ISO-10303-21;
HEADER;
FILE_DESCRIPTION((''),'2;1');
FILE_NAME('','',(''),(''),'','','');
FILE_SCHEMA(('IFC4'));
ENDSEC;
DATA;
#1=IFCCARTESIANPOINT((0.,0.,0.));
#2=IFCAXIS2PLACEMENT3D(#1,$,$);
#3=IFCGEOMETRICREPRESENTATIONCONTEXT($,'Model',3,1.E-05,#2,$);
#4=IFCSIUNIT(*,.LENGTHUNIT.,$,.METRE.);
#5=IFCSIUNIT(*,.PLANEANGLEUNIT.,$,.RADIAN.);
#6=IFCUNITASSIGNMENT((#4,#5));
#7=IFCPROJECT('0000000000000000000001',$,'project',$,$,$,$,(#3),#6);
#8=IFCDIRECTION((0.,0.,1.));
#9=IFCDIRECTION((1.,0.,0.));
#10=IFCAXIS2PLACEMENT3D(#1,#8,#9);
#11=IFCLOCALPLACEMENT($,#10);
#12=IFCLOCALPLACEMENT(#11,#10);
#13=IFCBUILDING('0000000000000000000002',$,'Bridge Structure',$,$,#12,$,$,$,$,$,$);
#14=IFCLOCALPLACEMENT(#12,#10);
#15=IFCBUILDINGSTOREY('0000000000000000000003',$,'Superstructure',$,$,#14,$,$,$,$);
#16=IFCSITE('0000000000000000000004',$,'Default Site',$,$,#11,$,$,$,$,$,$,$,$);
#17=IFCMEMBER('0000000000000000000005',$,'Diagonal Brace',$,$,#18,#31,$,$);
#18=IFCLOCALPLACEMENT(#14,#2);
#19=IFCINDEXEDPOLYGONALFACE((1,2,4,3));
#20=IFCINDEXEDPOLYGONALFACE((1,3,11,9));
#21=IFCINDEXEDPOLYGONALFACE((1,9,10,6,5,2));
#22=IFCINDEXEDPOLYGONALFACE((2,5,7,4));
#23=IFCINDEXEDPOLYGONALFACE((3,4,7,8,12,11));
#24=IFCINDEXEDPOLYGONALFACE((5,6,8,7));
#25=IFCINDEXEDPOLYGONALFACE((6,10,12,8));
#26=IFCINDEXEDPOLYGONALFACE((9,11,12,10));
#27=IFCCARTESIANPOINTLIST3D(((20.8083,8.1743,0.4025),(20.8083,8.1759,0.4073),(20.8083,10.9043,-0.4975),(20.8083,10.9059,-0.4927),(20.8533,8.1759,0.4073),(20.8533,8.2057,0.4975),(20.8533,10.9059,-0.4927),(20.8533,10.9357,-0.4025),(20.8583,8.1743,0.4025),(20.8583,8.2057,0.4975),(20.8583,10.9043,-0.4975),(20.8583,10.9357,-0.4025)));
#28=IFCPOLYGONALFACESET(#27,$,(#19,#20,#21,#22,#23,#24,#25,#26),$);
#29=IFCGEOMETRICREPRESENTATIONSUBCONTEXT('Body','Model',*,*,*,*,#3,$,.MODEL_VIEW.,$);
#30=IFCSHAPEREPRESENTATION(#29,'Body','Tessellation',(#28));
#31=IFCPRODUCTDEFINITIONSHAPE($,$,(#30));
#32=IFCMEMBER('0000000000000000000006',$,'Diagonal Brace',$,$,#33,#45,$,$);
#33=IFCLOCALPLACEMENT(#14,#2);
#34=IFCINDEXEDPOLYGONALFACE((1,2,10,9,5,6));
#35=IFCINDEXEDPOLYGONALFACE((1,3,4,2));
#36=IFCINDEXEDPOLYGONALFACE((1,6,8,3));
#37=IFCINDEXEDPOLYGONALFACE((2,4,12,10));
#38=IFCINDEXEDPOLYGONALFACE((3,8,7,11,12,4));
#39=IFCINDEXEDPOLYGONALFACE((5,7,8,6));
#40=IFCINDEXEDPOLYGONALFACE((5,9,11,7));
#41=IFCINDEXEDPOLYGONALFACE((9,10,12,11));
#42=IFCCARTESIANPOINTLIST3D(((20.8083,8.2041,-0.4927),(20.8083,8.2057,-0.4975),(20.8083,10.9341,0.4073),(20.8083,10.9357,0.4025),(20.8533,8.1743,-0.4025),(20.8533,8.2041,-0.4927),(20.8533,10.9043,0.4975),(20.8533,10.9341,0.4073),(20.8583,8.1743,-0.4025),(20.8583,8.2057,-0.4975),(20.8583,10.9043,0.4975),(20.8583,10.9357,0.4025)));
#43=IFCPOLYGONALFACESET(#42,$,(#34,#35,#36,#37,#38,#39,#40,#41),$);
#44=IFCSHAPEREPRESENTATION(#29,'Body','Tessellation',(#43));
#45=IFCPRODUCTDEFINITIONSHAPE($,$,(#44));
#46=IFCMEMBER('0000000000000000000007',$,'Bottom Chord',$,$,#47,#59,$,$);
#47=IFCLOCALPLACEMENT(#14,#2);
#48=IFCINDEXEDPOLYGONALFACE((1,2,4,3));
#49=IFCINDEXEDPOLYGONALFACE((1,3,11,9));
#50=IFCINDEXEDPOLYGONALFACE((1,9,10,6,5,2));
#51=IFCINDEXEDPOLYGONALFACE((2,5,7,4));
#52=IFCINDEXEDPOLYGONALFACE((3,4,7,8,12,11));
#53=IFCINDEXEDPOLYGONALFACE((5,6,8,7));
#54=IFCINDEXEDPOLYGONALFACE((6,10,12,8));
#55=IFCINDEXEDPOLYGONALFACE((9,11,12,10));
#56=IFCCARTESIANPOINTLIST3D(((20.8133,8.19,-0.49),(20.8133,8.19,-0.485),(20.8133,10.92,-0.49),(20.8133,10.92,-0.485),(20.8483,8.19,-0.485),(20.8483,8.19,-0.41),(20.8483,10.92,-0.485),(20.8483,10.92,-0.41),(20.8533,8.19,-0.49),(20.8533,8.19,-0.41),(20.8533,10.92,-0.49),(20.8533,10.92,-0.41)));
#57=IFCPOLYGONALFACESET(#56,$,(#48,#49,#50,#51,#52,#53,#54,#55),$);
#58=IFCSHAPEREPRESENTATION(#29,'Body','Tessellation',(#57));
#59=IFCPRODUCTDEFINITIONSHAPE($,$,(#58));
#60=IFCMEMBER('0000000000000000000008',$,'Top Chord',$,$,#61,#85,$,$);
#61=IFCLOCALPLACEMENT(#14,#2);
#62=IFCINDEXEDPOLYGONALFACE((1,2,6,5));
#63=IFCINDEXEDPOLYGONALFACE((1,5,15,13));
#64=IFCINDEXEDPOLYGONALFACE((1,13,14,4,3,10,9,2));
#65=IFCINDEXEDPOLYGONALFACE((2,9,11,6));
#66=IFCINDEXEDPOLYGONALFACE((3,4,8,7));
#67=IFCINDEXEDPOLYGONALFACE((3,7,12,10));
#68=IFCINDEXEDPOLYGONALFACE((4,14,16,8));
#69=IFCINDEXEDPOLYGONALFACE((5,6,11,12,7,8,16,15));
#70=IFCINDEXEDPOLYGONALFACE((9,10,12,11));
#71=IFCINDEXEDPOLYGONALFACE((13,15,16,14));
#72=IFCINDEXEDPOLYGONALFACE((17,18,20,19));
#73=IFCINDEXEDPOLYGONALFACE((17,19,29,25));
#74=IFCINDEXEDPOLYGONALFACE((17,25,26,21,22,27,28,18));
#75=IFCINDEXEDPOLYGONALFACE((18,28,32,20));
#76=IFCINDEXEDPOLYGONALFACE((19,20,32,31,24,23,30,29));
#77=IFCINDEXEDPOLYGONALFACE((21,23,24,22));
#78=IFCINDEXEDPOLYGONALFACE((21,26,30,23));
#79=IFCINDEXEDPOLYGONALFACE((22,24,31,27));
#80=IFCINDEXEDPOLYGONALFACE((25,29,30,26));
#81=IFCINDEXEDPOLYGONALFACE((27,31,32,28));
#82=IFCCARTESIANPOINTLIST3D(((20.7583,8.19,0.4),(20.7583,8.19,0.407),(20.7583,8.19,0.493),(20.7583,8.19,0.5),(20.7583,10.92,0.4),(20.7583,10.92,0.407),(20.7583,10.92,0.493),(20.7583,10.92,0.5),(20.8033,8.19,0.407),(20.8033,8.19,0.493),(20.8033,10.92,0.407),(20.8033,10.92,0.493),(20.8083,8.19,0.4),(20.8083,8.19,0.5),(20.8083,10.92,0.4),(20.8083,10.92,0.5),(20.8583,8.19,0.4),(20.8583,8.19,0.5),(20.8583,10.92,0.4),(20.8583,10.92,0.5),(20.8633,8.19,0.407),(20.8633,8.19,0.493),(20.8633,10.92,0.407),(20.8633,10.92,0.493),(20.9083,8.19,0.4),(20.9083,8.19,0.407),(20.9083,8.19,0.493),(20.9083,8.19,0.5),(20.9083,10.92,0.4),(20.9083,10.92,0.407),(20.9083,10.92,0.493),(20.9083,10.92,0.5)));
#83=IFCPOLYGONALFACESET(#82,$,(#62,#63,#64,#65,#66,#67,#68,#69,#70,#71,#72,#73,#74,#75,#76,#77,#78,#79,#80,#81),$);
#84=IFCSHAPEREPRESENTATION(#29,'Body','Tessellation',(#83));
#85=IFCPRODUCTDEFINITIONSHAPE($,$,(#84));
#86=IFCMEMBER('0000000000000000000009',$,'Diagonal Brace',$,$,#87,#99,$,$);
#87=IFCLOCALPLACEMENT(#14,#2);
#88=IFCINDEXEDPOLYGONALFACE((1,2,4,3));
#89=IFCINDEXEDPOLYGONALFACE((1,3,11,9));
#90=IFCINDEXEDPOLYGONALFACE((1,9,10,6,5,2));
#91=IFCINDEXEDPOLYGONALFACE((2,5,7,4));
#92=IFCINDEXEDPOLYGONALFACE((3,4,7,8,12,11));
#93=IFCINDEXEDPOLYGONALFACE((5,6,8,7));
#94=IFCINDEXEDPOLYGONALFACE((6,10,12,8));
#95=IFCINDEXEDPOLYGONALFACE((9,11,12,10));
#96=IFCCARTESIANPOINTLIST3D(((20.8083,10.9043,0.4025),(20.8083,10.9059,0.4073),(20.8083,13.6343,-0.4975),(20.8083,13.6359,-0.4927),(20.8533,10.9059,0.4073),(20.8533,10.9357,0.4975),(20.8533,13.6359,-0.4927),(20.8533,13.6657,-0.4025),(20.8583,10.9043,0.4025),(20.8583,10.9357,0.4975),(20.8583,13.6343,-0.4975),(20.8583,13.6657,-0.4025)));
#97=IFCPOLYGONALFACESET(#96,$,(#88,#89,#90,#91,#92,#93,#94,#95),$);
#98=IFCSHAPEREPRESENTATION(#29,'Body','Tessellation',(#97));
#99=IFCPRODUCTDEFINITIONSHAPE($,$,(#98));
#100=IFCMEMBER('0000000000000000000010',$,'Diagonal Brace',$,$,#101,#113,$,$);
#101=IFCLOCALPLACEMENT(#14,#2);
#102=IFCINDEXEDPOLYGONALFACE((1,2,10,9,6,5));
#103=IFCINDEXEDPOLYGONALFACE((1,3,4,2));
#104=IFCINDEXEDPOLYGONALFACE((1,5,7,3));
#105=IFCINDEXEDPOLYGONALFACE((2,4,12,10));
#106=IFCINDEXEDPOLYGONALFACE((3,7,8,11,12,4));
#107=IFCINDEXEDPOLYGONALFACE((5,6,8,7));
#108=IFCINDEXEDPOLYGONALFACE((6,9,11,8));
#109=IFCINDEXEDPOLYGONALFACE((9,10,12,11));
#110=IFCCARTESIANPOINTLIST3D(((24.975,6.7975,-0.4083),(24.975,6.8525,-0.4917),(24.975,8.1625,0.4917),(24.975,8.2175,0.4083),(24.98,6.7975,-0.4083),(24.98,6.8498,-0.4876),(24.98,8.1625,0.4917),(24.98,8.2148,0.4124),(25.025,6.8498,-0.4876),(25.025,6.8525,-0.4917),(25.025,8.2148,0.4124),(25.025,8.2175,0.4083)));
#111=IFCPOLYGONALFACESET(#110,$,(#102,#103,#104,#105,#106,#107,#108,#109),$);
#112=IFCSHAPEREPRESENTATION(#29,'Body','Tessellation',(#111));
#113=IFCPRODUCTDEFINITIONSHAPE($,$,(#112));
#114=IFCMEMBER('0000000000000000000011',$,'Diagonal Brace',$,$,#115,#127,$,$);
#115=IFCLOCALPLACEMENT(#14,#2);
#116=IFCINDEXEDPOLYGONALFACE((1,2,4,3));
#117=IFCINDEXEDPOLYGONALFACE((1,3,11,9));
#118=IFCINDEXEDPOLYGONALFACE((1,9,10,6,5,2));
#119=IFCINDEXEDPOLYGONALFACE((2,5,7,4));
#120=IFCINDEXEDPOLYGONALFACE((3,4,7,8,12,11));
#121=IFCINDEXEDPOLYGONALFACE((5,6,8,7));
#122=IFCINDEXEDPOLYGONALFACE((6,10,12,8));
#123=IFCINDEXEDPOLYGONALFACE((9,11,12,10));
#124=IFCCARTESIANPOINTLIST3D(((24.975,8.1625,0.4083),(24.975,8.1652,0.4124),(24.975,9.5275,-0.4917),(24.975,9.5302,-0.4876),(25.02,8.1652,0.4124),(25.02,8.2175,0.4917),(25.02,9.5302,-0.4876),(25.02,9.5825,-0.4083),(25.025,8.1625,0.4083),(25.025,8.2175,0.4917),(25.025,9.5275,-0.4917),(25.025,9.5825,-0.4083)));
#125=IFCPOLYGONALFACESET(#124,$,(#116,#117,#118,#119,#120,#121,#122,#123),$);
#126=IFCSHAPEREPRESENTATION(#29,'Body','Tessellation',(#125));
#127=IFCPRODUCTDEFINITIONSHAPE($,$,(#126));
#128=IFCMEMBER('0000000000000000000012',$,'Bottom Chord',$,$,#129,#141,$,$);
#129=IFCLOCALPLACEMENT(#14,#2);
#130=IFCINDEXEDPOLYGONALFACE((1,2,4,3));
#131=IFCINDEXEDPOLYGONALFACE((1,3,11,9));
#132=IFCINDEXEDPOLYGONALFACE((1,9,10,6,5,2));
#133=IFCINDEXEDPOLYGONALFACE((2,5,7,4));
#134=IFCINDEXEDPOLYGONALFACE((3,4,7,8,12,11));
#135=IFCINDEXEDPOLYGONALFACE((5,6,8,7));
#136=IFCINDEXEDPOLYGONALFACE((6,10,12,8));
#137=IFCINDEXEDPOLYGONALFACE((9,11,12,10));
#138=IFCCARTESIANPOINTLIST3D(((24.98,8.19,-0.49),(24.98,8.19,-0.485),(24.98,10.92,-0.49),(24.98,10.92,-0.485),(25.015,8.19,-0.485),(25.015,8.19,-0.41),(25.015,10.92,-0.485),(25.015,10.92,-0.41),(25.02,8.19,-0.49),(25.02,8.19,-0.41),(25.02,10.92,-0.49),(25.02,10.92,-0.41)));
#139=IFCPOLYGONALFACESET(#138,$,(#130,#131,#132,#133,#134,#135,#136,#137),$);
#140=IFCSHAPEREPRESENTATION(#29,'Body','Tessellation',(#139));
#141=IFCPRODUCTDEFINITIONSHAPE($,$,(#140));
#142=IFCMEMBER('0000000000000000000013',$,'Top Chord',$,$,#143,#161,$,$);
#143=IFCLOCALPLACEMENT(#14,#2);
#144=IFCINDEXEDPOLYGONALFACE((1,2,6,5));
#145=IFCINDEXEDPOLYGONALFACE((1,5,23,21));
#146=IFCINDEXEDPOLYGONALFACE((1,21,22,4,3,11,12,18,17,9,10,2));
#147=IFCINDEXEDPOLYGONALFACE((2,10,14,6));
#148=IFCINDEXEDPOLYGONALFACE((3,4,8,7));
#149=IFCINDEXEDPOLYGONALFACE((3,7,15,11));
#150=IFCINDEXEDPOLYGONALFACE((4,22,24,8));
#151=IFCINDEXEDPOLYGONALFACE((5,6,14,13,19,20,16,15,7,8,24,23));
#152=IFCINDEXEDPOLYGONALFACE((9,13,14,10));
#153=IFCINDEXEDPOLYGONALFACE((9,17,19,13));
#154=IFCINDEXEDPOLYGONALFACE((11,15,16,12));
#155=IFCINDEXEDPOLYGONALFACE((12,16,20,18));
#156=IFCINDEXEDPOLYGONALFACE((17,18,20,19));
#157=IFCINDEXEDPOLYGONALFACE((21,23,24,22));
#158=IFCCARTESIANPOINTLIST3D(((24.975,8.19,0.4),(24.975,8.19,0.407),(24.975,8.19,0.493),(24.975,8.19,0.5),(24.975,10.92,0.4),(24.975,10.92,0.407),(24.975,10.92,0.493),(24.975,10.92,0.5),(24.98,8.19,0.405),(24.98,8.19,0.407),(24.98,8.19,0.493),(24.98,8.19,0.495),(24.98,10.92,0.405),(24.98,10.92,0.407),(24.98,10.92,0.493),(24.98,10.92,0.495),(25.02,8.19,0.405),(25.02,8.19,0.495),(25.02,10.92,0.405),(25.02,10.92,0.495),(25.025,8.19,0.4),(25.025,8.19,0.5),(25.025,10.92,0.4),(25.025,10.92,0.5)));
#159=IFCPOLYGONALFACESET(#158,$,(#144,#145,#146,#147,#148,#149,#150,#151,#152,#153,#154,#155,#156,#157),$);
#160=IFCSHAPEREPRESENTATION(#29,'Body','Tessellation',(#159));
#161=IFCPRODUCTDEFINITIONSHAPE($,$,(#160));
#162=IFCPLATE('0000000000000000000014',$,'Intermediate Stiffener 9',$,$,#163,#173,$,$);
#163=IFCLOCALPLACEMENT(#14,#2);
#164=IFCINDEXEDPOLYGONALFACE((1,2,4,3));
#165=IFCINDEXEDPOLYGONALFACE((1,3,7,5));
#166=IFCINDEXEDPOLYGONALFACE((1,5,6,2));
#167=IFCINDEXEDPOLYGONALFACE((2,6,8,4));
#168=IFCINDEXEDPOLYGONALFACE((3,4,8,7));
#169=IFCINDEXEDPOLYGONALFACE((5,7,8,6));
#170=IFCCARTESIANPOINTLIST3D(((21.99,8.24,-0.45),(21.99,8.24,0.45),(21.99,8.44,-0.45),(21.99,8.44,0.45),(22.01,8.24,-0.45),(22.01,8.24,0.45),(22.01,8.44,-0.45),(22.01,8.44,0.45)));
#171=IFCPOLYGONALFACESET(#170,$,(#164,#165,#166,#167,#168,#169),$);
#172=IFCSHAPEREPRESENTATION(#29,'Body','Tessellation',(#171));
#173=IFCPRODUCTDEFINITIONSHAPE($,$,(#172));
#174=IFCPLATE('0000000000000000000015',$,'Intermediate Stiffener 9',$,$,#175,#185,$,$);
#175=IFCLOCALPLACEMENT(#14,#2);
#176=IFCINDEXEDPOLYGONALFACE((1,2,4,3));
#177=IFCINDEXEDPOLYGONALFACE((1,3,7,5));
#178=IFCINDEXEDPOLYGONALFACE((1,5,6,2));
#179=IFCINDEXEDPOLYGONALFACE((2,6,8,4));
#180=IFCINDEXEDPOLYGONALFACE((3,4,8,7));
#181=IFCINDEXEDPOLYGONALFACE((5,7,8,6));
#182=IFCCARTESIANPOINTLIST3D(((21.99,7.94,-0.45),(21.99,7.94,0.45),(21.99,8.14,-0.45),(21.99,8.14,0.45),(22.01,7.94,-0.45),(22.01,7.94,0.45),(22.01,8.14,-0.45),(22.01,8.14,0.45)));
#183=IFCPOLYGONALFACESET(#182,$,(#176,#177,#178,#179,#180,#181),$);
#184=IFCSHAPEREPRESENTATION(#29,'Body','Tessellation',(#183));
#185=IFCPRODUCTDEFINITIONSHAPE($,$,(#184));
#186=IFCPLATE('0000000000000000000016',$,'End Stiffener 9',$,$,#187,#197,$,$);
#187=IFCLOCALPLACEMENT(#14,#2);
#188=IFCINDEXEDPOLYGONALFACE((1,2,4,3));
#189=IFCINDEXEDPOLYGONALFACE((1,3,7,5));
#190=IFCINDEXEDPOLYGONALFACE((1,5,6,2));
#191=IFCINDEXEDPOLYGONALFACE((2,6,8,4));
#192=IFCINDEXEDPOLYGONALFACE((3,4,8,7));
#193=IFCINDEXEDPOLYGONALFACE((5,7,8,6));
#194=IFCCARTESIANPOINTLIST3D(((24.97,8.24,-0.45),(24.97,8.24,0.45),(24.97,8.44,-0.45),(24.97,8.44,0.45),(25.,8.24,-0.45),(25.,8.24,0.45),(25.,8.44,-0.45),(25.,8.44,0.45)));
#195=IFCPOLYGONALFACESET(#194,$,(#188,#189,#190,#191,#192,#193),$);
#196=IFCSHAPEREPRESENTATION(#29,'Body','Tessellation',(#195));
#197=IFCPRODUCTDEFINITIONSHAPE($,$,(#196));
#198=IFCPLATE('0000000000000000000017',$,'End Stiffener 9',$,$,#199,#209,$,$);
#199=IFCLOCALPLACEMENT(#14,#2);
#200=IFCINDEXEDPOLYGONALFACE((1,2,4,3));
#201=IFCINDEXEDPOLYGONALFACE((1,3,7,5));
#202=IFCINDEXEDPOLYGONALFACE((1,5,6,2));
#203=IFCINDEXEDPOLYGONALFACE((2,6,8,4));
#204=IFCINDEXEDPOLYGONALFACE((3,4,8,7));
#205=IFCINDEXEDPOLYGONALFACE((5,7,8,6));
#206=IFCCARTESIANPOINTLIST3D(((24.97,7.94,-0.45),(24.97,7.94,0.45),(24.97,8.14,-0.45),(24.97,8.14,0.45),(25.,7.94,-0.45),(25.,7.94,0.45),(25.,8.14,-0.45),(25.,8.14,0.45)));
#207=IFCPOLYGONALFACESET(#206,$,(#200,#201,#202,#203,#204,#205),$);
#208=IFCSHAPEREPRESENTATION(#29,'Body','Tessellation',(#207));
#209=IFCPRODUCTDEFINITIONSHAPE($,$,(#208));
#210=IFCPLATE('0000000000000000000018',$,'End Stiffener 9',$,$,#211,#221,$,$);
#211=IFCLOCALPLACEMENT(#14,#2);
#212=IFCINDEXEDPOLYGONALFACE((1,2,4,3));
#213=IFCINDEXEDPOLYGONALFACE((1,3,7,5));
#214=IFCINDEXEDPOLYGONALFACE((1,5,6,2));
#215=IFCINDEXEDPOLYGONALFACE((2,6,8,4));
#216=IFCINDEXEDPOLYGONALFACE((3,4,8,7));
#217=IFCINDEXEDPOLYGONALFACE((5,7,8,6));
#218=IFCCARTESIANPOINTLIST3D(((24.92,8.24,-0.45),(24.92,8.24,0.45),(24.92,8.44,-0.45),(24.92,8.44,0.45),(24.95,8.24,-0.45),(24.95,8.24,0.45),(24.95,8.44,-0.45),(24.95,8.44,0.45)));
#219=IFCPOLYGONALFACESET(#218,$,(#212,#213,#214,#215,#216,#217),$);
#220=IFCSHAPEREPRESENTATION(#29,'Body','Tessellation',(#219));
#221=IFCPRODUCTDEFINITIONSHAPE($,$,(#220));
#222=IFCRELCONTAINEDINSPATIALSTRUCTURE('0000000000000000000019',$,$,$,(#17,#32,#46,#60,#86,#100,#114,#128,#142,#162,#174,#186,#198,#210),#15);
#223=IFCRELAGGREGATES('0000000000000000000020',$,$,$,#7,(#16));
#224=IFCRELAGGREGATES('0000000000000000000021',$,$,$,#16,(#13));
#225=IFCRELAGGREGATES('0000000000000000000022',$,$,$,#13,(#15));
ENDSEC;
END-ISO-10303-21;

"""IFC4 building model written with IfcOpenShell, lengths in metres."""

from ifc_helpers import new_model, si_unit, frame, origin, origin_with_axes, origin_2d_with_axis, place, context, subcontext, project, spatial, polyline, rectangle, l_section, c_section, outline, composite_profile, extrude, element, save


model = new_model("IFC4")

# Units and contexts
model_context = context("Model", 3, precision=1e-05, world=origin())
body_context = subcontext(model_context, "Body", "Model", "MODEL_VIEW")
ifc_project = project(units=[si_unit("LENGTHUNIT", "METRE"), si_unit("PLANEANGLEUNIT", "RADIAN")], contexts=[model_context])

# Site, building, storey
site_placement = place(None, origin_with_axes())
site = spatial("IfcSite", under=ifc_project, at=site_placement, Name="Default Site")
building_placement = place(site_placement, origin_with_axes())
building = spatial("IfcBuilding", under=site, at=building_placement, Name="Bridge Structure")
storey_placement = place(building_placement, origin_with_axes())
storey = spatial("IfcBuildingStorey", under=building, at=storey_placement, Name="Superstructure")

# Members
for number, where, z_axis, x_axis, name in (
    (1, (20.8333, 8.19, 0.45), (0.0, 0.949722, -0.313095), (-1.0, 0.0, 0.0), "Diagonal Brace"),
    (2, (20.8333, 8.19, -0.45), (0.0, 0.949722, 0.313095), (-1.0, 0.0, 0.0), "Diagonal Brace"),
):
    element("IfcMember", number, at=place(storey_placement, frame(where, z_axis=z_axis, x_axis=x_axis)), inside=storey, Name=name, context=body_context, shape_type="SweptSolid", body=[
        extrude(l_section(Depth=0.1, Width=0.05, Thickness=0.005, at=origin_2d_with_axis()), origin_with_axes(), (0.0, 0.0, 1.0), 2.8745),
    ])
member_1_placement = place(storey_placement, frame((20.8333, 8.19, -0.45), z_axis=(0.0, 1.0, 0.0), x_axis=(-1.0, 0.0, 0.0)))
element("IfcMember", 3, at=member_1_placement, inside=storey, Name="Bottom Chord", context=body_context, shape_type="SweptSolid", body=[
    extrude(l_section(Depth=0.08, Width=0.04, Thickness=0.005, at=origin_2d_with_axis()), origin_with_axes(), (0.0, 0.0, 1.0), 2.73),
])
member_2_placement = place(storey_placement, frame((20.8333, 8.19, 0.45), z_axis=(0.0, 1.0, 0.0), x_axis=(-1.0, 0.0, 0.0)))
element("IfcMember", 4, at=member_2_placement, inside=storey, Name="Top Chord", context=body_context, shape_type="SweptSolid", body=[
    extrude(composite_profile([outline(polyline([(-0.025, -0.05), (-0.025, 0.05), (-0.075, 0.05), (-0.075, 0.043), (-0.03, 0.043), (-0.03, -0.043), (-0.075, -0.043), (-0.075, -0.05), (-0.025, -0.05)])), outline(polyline([(0.025, -0.05), (0.075, -0.05), (0.075, -0.043), (0.03, -0.043), (0.03, 0.043), (0.075, 0.043), (0.075, 0.05), (0.025, 0.05), (0.025, -0.05)]))]), origin_with_axes(), (0.0, 0.0, 1.0), 2.73),
])
member_3_placement = place(storey_placement, frame((20.8333, 10.92, 0.45), z_axis=(0.0, 0.949722, -0.313095), x_axis=(-1.0, 0.0, 0.0)))
element("IfcMember", 5, at=member_3_placement, inside=storey, Name="Diagonal Brace", context=body_context, shape_type="SweptSolid", body=[
    extrude(l_section(Depth=0.1, Width=0.05, Thickness=0.005, at=origin_2d_with_axis()), origin_with_axes(), (0.0, 0.0, 1.0), 2.8745),
])
for number, where, z_axis, x_axis, name in (
    (6, (25.0, 8.19, 0.45), (0.0, -0.834862, -0.550459), (1.0, 0.0, 0.0), "Diagonal Brace"),
    (7, (25.0, 8.19, 0.45), (0.0, 0.834862, -0.550459), (-1.0, 0.0, 0.0), "Diagonal Brace"),
):
    element("IfcMember", number, at=place(storey_placement, frame(where, z_axis=z_axis, x_axis=x_axis)), inside=storey, Name=name, context=body_context, shape_type="SweptSolid", body=[
        extrude(l_section(Depth=0.1, Width=0.05, Thickness=0.005, at=origin_2d_with_axis()), origin_with_axes(), (0.0, 0.0, 1.0), 1.635),
    ])
member_4_placement = place(storey_placement, frame((25.0, 8.19, -0.45), z_axis=(0.0, 1.0, 0.0), x_axis=(-1.0, 0.0, 0.0)))
element("IfcMember", 8, at=member_4_placement, inside=storey, Name="Bottom Chord", context=body_context, shape_type="SweptSolid", body=[
    extrude(l_section(Depth=0.08, Width=0.04, Thickness=0.005, at=origin_2d_with_axis()), origin_with_axes(), (0.0, 0.0, 1.0), 2.73),
])
member_5_placement = place(storey_placement, frame((25.0, 8.19, 0.45), z_axis=(0.0, 1.0, 0.0), x_axis=(-1.0, 0.0, 0.0)))
element("IfcMember", 9, at=member_5_placement, inside=storey, Name="Top Chord", context=body_context, shape_type="SweptSolid", body=[
    extrude(c_section(Depth=0.1, Width=0.05, WallThickness=0.005, Girth=0.007, at=origin_2d_with_axis()), origin_with_axes(), (0.0, 0.0, 1.0), 2.73),
])

# Plates
for number, where, z_axis, x_axis, name in (
    (10, (22.0, 8.34, -0.45), (0.0, 0.0, 1.0), (1.0, 0.0, 0.0), "Intermediate Stiffener 9"),
    (11, (22.0, 8.04, -0.45), (0.0, 0.0, 1.0), (1.0, 0.0, 0.0), "Intermediate Stiffener 9"),
):
    element("IfcPlate", number, at=place(storey_placement, frame(where, z_axis=z_axis, x_axis=x_axis)), inside=storey, Name=name, context=body_context, shape_type="SweptSolid", body=[
        extrude(rectangle(XDim=0.02, YDim=0.2, at=origin_2d_with_axis()), origin_with_axes(), (0.0, 0.0, 1.0), 0.9),
    ])
for number, where, z_axis, x_axis, name in (
    (12, (24.985, 8.34, -0.45), (0.0, 0.0, 1.0), (1.0, 0.0, 0.0), "End Stiffener 9"),
    (13, (24.985, 8.04, -0.45), (0.0, 0.0, 1.0), (1.0, 0.0, 0.0), "End Stiffener 9"),
    (14, (24.935, 8.34, -0.45), (0.0, 0.0, 1.0), (1.0, 0.0, 0.0), "End Stiffener 9"),
):
    element("IfcPlate", number, at=place(storey_placement, frame(where, z_axis=z_axis, x_axis=x_axis)), inside=storey, Name=name, context=body_context, shape_type="SweptSolid", body=[
        extrude(rectangle(XDim=0.03, YDim=0.2, at=origin_2d_with_axis()), origin_with_axes(), (0.0, 0.0, 1.0), 0.9),
    ])

save(model, "model.ifc")
